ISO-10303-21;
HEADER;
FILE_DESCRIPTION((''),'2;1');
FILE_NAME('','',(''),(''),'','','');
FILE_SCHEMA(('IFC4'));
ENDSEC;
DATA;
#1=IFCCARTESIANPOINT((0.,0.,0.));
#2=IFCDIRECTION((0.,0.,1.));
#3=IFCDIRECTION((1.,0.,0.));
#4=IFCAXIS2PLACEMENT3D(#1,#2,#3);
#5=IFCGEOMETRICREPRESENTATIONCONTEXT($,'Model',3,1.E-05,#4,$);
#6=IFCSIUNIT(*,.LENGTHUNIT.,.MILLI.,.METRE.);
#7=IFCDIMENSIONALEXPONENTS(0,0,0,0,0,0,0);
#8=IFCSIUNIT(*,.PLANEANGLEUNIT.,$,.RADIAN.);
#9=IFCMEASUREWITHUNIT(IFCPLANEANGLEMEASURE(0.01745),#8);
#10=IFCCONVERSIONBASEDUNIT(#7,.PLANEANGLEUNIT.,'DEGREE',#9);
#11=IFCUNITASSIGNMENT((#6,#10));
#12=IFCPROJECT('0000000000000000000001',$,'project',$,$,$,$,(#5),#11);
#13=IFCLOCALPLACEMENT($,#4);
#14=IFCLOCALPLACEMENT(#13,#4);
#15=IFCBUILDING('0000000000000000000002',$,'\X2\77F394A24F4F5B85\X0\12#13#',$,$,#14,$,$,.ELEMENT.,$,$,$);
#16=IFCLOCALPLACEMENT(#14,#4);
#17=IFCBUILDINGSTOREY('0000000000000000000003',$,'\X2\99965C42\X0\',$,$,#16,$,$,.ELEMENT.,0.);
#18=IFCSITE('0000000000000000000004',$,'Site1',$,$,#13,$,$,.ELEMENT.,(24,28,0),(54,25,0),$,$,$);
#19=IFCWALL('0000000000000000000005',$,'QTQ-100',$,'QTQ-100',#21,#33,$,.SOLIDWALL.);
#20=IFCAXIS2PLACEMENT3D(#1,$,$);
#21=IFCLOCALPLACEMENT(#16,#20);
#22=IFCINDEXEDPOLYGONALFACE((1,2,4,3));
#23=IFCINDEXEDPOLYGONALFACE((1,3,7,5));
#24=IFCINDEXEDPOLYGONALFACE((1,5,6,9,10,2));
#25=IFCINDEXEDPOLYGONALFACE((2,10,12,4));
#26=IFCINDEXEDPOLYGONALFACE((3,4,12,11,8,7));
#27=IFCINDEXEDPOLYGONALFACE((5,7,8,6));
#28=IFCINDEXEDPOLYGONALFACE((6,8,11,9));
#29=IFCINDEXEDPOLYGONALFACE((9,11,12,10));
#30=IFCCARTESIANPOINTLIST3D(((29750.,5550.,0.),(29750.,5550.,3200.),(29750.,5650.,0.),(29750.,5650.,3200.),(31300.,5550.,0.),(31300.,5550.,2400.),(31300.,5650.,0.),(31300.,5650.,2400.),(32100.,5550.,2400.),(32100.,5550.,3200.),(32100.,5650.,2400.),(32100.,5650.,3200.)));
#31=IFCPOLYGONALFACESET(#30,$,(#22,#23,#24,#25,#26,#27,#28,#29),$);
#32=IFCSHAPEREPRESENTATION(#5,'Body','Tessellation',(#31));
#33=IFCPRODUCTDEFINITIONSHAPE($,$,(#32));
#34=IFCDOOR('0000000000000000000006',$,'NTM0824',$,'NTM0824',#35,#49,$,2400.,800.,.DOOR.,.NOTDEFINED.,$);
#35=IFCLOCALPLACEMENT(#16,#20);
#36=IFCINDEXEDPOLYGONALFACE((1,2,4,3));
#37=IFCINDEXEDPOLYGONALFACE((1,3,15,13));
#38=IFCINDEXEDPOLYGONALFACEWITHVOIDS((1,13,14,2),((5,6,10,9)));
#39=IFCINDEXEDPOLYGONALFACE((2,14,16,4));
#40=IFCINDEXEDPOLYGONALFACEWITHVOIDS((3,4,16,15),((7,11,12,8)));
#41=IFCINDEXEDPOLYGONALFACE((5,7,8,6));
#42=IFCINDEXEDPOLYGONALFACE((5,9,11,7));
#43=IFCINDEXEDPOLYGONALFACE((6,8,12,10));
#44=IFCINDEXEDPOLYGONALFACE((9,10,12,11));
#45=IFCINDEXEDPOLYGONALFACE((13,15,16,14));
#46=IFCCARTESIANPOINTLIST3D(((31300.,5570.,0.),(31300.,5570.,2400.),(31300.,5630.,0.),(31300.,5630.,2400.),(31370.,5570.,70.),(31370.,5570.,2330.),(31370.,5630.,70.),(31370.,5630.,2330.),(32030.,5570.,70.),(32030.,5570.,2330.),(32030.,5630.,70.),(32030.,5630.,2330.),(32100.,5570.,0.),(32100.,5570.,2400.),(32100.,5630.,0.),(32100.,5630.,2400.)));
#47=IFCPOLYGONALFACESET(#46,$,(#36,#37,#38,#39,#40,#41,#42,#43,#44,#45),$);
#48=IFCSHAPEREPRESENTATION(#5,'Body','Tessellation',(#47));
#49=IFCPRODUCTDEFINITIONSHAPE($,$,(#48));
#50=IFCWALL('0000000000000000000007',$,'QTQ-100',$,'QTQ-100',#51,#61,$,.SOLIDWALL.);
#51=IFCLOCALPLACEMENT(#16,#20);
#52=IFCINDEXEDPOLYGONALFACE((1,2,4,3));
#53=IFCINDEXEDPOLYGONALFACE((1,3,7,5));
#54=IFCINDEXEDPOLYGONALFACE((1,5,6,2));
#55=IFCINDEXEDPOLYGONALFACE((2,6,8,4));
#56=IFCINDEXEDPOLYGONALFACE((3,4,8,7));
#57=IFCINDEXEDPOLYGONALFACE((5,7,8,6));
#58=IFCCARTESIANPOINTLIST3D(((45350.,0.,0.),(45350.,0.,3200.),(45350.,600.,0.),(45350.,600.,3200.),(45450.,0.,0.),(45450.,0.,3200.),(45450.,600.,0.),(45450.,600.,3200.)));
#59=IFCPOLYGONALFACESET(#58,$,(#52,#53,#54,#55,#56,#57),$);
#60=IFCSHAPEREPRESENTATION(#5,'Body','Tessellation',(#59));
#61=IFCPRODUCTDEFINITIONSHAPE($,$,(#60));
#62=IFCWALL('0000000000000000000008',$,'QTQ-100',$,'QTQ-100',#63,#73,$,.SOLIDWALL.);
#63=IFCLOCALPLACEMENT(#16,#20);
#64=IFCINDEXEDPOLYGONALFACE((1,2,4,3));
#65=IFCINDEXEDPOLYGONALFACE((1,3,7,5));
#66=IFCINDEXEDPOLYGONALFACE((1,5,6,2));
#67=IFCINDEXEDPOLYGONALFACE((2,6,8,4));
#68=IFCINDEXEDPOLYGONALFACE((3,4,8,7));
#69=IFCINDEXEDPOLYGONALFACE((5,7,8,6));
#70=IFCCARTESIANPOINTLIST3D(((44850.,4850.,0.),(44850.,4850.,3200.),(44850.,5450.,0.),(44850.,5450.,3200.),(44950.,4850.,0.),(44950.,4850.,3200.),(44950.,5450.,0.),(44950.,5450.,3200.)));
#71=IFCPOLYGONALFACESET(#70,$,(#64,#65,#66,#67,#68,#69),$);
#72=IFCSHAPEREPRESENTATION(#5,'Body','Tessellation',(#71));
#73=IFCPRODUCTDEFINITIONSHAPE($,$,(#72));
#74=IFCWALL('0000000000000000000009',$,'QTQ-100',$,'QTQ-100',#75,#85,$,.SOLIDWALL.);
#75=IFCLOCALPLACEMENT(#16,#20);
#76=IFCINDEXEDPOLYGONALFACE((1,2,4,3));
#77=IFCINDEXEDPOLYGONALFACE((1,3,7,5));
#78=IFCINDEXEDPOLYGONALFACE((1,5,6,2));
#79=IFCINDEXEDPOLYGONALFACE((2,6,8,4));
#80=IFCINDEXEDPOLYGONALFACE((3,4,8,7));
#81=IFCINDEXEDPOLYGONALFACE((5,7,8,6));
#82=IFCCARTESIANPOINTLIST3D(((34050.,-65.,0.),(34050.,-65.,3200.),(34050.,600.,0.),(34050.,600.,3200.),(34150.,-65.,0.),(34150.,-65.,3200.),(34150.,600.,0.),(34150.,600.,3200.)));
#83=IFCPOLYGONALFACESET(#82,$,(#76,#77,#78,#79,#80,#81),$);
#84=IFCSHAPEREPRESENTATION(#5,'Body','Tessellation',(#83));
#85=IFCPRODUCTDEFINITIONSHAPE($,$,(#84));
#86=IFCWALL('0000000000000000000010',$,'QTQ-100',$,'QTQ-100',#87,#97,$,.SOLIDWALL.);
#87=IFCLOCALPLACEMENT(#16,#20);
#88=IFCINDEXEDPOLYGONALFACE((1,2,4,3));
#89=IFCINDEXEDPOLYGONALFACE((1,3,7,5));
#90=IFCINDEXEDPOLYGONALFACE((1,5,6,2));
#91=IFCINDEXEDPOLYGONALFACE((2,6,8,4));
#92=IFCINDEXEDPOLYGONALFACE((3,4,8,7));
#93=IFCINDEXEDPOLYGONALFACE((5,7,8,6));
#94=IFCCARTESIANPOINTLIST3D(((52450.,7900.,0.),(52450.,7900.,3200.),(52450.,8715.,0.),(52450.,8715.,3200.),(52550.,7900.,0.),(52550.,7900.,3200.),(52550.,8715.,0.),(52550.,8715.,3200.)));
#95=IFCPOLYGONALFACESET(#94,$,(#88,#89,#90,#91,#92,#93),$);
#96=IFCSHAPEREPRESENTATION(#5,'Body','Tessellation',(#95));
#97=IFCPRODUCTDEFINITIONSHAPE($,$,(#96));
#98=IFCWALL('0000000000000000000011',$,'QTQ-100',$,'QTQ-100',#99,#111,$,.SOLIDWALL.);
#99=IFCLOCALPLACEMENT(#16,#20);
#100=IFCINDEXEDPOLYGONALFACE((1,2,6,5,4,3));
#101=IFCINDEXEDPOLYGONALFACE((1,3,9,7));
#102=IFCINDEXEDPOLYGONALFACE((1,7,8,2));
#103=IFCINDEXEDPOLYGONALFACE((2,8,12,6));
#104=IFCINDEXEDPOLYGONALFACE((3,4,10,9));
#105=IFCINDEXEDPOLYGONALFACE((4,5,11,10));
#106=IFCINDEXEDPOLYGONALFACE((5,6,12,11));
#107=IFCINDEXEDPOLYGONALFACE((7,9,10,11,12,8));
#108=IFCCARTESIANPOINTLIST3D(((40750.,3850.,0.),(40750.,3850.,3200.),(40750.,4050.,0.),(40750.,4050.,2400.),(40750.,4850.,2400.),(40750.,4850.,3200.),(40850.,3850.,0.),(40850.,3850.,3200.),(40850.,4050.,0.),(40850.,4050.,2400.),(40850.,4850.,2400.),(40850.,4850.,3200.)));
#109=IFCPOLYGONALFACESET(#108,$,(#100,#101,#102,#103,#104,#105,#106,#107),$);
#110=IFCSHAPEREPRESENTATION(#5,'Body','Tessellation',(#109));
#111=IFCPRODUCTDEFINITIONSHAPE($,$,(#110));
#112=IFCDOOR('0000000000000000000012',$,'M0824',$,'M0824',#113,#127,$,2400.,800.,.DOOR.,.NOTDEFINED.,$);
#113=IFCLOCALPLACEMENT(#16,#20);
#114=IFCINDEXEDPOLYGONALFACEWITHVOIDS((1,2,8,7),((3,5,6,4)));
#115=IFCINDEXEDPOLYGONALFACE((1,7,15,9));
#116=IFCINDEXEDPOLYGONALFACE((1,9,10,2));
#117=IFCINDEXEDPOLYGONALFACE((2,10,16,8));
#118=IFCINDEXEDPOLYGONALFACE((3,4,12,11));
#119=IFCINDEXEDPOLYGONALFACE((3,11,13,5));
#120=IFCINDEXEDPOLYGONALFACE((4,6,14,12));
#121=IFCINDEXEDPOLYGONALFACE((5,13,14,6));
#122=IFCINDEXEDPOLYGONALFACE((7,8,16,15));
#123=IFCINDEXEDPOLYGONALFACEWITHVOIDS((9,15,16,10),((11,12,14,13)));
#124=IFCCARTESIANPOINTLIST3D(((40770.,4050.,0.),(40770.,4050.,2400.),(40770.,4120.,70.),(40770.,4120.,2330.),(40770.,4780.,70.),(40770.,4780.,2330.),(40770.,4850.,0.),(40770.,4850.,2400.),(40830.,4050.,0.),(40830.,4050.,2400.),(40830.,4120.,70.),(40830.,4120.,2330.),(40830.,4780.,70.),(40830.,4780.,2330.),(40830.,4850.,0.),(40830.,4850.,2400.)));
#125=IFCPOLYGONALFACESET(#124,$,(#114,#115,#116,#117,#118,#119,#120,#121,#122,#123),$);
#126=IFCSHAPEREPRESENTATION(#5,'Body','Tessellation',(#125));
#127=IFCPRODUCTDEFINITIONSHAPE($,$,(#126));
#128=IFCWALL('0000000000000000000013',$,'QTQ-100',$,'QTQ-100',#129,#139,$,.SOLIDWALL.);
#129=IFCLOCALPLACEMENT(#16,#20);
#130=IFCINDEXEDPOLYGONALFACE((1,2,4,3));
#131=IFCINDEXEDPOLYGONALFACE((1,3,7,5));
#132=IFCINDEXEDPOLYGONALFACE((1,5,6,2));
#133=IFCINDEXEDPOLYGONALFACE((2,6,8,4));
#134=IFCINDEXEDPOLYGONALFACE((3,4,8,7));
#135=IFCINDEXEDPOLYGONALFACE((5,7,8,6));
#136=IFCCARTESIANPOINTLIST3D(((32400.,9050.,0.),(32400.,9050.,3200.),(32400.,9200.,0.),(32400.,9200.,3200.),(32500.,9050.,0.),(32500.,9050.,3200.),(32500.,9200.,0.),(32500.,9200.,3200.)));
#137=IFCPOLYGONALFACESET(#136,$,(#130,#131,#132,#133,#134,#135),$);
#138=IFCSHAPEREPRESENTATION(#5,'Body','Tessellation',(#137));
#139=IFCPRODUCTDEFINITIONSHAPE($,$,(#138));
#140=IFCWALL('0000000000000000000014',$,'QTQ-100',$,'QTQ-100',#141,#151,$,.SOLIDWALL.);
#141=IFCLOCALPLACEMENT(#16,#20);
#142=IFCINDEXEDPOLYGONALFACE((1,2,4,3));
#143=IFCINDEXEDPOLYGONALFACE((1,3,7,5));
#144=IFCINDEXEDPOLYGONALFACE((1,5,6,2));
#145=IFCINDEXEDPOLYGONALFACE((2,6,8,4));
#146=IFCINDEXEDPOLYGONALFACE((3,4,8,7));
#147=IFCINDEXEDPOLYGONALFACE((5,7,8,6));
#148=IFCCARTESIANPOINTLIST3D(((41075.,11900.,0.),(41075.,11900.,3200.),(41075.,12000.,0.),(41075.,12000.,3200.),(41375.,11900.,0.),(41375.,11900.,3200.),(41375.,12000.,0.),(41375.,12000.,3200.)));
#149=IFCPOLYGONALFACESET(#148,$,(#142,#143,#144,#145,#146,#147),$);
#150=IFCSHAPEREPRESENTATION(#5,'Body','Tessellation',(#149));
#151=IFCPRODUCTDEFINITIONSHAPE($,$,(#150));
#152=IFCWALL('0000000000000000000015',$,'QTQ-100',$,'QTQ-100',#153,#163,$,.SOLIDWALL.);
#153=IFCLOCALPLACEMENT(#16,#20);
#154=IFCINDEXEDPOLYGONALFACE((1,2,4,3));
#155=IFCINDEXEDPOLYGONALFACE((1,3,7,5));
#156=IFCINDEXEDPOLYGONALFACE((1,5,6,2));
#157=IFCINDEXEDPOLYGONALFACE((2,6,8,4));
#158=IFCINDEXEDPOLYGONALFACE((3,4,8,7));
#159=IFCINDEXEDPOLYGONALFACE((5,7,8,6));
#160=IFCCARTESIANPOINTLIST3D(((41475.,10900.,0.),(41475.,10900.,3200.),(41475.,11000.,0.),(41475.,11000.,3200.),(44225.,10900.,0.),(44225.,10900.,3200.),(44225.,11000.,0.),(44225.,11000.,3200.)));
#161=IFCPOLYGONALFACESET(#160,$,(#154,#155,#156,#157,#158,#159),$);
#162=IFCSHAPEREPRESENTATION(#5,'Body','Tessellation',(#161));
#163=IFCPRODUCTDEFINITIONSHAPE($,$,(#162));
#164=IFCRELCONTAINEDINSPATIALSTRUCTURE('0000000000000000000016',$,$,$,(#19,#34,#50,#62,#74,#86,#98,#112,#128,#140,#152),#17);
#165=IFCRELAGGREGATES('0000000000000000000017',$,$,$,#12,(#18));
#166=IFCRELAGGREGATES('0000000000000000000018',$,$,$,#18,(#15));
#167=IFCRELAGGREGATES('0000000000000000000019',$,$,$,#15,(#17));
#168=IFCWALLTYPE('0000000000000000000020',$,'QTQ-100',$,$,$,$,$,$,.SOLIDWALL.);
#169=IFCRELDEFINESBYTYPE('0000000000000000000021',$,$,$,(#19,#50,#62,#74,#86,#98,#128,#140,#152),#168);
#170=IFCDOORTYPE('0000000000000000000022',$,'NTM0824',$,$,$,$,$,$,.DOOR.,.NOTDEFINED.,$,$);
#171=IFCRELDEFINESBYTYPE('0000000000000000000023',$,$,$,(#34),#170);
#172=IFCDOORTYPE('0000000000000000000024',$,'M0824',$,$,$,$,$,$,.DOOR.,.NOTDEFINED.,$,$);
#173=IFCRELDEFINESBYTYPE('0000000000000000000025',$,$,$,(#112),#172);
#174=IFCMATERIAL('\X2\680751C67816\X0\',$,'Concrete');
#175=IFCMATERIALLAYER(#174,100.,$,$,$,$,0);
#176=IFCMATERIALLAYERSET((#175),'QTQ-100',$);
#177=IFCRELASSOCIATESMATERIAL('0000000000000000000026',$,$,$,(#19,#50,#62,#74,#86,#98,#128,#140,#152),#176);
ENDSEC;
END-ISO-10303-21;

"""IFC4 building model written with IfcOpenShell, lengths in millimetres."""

from ifc_helpers import new_model, entity, si_unit, converted_unit, frame, origin_with_axes, place, context, project, spatial, polyline, outline, extrude, material, layer, layer_set, type_object, element, fill, save


model = new_model("IFC4")

# Units and contexts
model_context = context("Model", 3, precision=1e-05, world=origin_with_axes())
ifc_project = project(units=[si_unit("LENGTHUNIT", "METRE", prefix="MILLI"), converted_unit("PLANEANGLEUNIT", "DEGREE", entity("IfcPlaneAngleMeasure", 0.01745), si_unit("PLANEANGLEUNIT", "RADIAN"), dimensions=[0, 0, 0, 0, 0, 0, 0])], contexts=[model_context])

# Site, building, storey
site_placement = place(None, origin_with_axes())
site = spatial("IfcSite", under=ifc_project, at=site_placement, Name="Site1", CompositionType="ELEMENT", RefLatitude=(24, 28, 0), RefLongitude=(54, 25, 0))
building_placement = place(site_placement, origin_with_axes())
building = spatial("IfcBuilding", under=site, at=building_placement, Name="石钢住宅12#13#", CompositionType="ELEMENT")
storey_placement = place(building_placement, origin_with_axes())
storey = spatial("IfcBuildingStorey", under=building, at=storey_placement, Name="首层", CompositionType="ELEMENT", Elevation=0.0)

# Shared definitions
ifc_material = material(Name="标准砖", Category="Concrete")
ifc_layer = layer(ifc_material, 100.0, Priority=0)
ifc_layer_set = layer_set([ifc_layer], Name="QTQ-100")
wall_type = type_object("IfcWallType", Name="QTQ-100", PredefinedType="SOLIDWALL")
door_type_1 = type_object("IfcDoorType", Name="M0824", OperationType="NOTDEFINED", PredefinedType="DOOR")

# Wall, opening, door
wall_1_placement = place(storey_placement, origin_with_axes())
wall_1 = element("IfcWall", 1, at=wall_1_placement, inside=storey, type_object=wall_type, material=ifc_layer_set, Name="QTQ-100", ObjectType="QTQ-100", PredefinedType="SOLIDWALL", context=model_context, shape_type="SweptSolid", body=[
    extrude(outline(polyline([(0.0, 0.0), (3200.0, 0.0), (3200.0, 2350.0), (0.0, 2350.0), (0.0, 0.0)])), frame((32100.0, 5550.0, 3200.0), z_axis=(0.0, 1.0, 0.0), x_axis=(0.0, 0.0, -1.0)), (0.0, 0.0, 1.0), 100.0),
])
opening_1_placement = place(storey_placement, origin_with_axes())
opening_1 = element("IfcOpeningElement", 2, at=opening_1_placement, cuts=wall_1, PredefinedType="OPENING", context=model_context, shape_type="SweptSolid", body=[
    extrude(outline(polyline([(0.0, 0.0), (800.0, 0.0), (800.0, 2400.0), (0.0, 2400.0), (0.0, 0.0)])), frame((32100.0, 4550.0, 0.0), z_axis=(0.0, 1.0, 0.0), x_axis=(-1.0, 0.0, 0.0)), (0.0, 0.0, 1.0), 2100.0),
])
door_type_2 = type_object("IfcDoorType", Name="NTM0824", OperationType="NOTDEFINED", PredefinedType="DOOR")
door_1_placement = place(storey_placement, origin_with_axes())
door_1 = element("IfcDoor", 3, at=door_1_placement, inside=storey, type_object=door_type_2, Name="NTM0824", ObjectType="NTM0824", OperationType="NOTDEFINED", OverallHeight=2400.0, OverallWidth=800.0, PredefinedType="DOOR", context=model_context, shape_type="SweptSolid", body=[
    extrude(outline(polyline([(-400.0, -1200.0), (400.0, -1200.0), (400.0, 1200.0), (-400.0, 1200.0), (-400.0, -1200.0)]), holes=[polyline([(-330.0, -1130.0), (-330.0, 1130.0), (330.0, 1130.0), (330.0, -1130.0), (-330.0, -1130.0)])]), frame((31700.0, 5570.0, 1200.0), z_axis=(0.0, 1.0, 0.0), x_axis=(-1.0, 0.0, 0.0)), (0.0, 0.0, 1.0), 60.0),
])
fill(opening_1, door_1)

# Walls
wall_2_placement = place(storey_placement, origin_with_axes())
element("IfcWall", 4, at=wall_2_placement, inside=storey, type_object=wall_type, material=ifc_layer_set, Name="QTQ-100", ObjectType="QTQ-100", PredefinedType="SOLIDWALL", context=model_context, shape_type="SweptSolid", body=[
    extrude(outline(polyline([(0.0, 0.0), (3200.0, 0.0), (3200.0, 600.0), (0.0, 600.0), (0.0, 0.0)])), frame((45450.0, 600.0, 3200.0), z_axis=(-1.0, 0.0, 0.0), x_axis=(0.0, 0.0, -1.0)), (0.0, 0.0, 1.0), 100.0),
])
wall_3_placement = place(storey_placement, origin_with_axes())
element("IfcWall", 5, at=wall_3_placement, inside=storey, type_object=wall_type, material=ifc_layer_set, Name="QTQ-100", ObjectType="QTQ-100", PredefinedType="SOLIDWALL", context=model_context, shape_type="SweptSolid", body=[
    extrude(outline(polyline([(0.0, 0.0), (3200.0, 0.0), (3200.0, 600.0), (0.0, 600.0), (0.0, 0.0)])), frame((44850.0, 4850.0, 3200.0), z_axis=(1.0, 0.0, 0.0), x_axis=(0.0, 0.0, -1.0)), (0.0, 0.0, 1.0), 100.0),
])
wall_4_placement = place(storey_placement, origin_with_axes())
element("IfcWall", 6, at=wall_4_placement, inside=storey, type_object=wall_type, material=ifc_layer_set, Name="QTQ-100", ObjectType="QTQ-100", PredefinedType="SOLIDWALL", context=model_context, shape_type="SweptSolid", body=[
    extrude(outline(polyline([(0.0, 0.0), (3200.0, 0.0), (3200.0, 665.0), (0.0, 665.0), (0.0, 0.0)])), frame((34150.0, 600.0, 3200.0), z_axis=(-1.0, 0.0, 0.0), x_axis=(0.0, 0.0, -1.0)), (0.0, 0.0, 1.0), 100.0),
])
wall_5_placement = place(storey_placement, origin_with_axes())
element("IfcWall", 7, at=wall_5_placement, inside=storey, type_object=wall_type, material=ifc_layer_set, Name="QTQ-100", ObjectType="QTQ-100", PredefinedType="SOLIDWALL", context=model_context, shape_type="SweptSolid", body=[
    extrude(outline(polyline([(0.0, 0.0), (3200.0, 0.0), (3200.0, 815.0), (0.0, 815.0), (0.0, 0.0)])), frame((52450.0, 7900.0, 3200.0), z_axis=(1.0, 0.0, 0.0), x_axis=(0.0, 0.0, -1.0)), (0.0, 0.0, 1.0), 100.0),
])

# Wall, opening, door
wall_6_placement = place(storey_placement, origin_with_axes())
wall_6 = element("IfcWall", 8, at=wall_6_placement, inside=storey, type_object=wall_type, material=ifc_layer_set, Name="QTQ-100", ObjectType="QTQ-100", PredefinedType="SOLIDWALL", context=model_context, shape_type="SweptSolid", body=[
    extrude(outline(polyline([(0.0, 0.0), (3200.0, 0.0), (3200.0, 1000.0), (0.0, 1000.0), (0.0, 0.0)])), frame((40750.0, 3850.0, 3200.0), z_axis=(1.0, 0.0, 0.0), x_axis=(0.0, 0.0, -1.0)), (0.0, 0.0, 1.0), 100.0),
])
opening_2_placement = place(storey_placement, origin_with_axes())
opening_2 = element("IfcOpeningElement", 9, at=opening_2_placement, cuts=wall_6, PredefinedType="OPENING", context=model_context, shape_type="SweptSolid", body=[
    extrude(outline(polyline([(0.0, 0.0), (800.0, 0.0), (800.0, 2400.0), (0.0, 2400.0), (0.0, 0.0)])), frame((39750.0, 4050.0, 0.0), z_axis=(1.0, 0.0, 0.0), x_axis=(0.0, 1.0, 0.0)), (0.0, 0.0, 1.0), 2100.0),
])
door_2_placement = place(storey_placement, origin_with_axes())
door_2 = element("IfcDoor", 10, at=door_2_placement, inside=storey, type_object=door_type_1, Name="M0824", ObjectType="M0824", OperationType="NOTDEFINED", OverallHeight=2400.0, OverallWidth=800.0, PredefinedType="DOOR", context=model_context, shape_type="SweptSolid", body=[
    extrude(outline(polyline([(-400.0, -1200.0), (400.0, -1200.0), (400.0, 1200.0), (-400.0, 1200.0), (-400.0, -1200.0)]), holes=[polyline([(-330.0, -1130.0), (-330.0, 1130.0), (330.0, 1130.0), (330.0, -1130.0), (-330.0, -1130.0)])]), frame((40770.0, 4450.0, 1200.0), z_axis=(1.0, 0.0, 0.0), x_axis=(0.0, 1.0, 0.0)), (0.0, 0.0, 1.0), 60.0),
])
fill(opening_2, door_2)

# Walls
wall_7_placement = place(storey_placement, origin_with_axes())
element("IfcWall", 11, at=wall_7_placement, inside=storey, type_object=wall_type, material=ifc_layer_set, Name="QTQ-100", ObjectType="QTQ-100", PredefinedType="SOLIDWALL", context=model_context, shape_type="SweptSolid", body=[
    extrude(outline(polyline([(0.0, 0.0), (3200.0, 0.0), (3200.0, 150.0), (0.0, 150.0), (0.0, 0.0)])), frame((32500.0, 9200.0, 3200.0), z_axis=(-1.0, 0.0, 0.0), x_axis=(0.0, 0.0, -1.0)), (0.0, 0.0, 1.0), 100.0),
])
wall_8_placement = place(storey_placement, origin_with_axes())
element("IfcWall", 12, at=wall_8_placement, inside=storey, type_object=wall_type, material=ifc_layer_set, Name="QTQ-100", ObjectType="QTQ-100", PredefinedType="SOLIDWALL", context=model_context, shape_type="SweptSolid", body=[
    extrude(outline(polyline([(0.0, 0.0), (3200.0, 0.0), (3200.0, 300.0), (0.0, 300.0), (0.0, 0.0)])), frame((41375.0, 11900.0, 3200.0), z_axis=(0.0, 1.0, 0.0), x_axis=(0.0, 0.0, -1.0)), (0.0, 0.0, 1.0), 100.0),
])
wall_9_placement = place(storey_placement, origin_with_axes())
element("IfcWall", 13, at=wall_9_placement, inside=storey, type_object=wall_type, material=ifc_layer_set, Name="QTQ-100", ObjectType="QTQ-100", PredefinedType="SOLIDWALL", context=model_context, shape_type="SweptSolid", body=[
    extrude(outline(polyline([(0.0, 0.0), (3200.0, 0.0), (3200.0, 2750.0), (0.0, 2750.0), (0.0, 0.0)])), frame((44225.0, 10900.0, 3200.0), z_axis=(0.0, 1.0, 0.0), x_axis=(0.0, 0.0, -1.0)), (0.0, 0.0, 1.0), 100.0),
])

save(model, "model.ifc")
